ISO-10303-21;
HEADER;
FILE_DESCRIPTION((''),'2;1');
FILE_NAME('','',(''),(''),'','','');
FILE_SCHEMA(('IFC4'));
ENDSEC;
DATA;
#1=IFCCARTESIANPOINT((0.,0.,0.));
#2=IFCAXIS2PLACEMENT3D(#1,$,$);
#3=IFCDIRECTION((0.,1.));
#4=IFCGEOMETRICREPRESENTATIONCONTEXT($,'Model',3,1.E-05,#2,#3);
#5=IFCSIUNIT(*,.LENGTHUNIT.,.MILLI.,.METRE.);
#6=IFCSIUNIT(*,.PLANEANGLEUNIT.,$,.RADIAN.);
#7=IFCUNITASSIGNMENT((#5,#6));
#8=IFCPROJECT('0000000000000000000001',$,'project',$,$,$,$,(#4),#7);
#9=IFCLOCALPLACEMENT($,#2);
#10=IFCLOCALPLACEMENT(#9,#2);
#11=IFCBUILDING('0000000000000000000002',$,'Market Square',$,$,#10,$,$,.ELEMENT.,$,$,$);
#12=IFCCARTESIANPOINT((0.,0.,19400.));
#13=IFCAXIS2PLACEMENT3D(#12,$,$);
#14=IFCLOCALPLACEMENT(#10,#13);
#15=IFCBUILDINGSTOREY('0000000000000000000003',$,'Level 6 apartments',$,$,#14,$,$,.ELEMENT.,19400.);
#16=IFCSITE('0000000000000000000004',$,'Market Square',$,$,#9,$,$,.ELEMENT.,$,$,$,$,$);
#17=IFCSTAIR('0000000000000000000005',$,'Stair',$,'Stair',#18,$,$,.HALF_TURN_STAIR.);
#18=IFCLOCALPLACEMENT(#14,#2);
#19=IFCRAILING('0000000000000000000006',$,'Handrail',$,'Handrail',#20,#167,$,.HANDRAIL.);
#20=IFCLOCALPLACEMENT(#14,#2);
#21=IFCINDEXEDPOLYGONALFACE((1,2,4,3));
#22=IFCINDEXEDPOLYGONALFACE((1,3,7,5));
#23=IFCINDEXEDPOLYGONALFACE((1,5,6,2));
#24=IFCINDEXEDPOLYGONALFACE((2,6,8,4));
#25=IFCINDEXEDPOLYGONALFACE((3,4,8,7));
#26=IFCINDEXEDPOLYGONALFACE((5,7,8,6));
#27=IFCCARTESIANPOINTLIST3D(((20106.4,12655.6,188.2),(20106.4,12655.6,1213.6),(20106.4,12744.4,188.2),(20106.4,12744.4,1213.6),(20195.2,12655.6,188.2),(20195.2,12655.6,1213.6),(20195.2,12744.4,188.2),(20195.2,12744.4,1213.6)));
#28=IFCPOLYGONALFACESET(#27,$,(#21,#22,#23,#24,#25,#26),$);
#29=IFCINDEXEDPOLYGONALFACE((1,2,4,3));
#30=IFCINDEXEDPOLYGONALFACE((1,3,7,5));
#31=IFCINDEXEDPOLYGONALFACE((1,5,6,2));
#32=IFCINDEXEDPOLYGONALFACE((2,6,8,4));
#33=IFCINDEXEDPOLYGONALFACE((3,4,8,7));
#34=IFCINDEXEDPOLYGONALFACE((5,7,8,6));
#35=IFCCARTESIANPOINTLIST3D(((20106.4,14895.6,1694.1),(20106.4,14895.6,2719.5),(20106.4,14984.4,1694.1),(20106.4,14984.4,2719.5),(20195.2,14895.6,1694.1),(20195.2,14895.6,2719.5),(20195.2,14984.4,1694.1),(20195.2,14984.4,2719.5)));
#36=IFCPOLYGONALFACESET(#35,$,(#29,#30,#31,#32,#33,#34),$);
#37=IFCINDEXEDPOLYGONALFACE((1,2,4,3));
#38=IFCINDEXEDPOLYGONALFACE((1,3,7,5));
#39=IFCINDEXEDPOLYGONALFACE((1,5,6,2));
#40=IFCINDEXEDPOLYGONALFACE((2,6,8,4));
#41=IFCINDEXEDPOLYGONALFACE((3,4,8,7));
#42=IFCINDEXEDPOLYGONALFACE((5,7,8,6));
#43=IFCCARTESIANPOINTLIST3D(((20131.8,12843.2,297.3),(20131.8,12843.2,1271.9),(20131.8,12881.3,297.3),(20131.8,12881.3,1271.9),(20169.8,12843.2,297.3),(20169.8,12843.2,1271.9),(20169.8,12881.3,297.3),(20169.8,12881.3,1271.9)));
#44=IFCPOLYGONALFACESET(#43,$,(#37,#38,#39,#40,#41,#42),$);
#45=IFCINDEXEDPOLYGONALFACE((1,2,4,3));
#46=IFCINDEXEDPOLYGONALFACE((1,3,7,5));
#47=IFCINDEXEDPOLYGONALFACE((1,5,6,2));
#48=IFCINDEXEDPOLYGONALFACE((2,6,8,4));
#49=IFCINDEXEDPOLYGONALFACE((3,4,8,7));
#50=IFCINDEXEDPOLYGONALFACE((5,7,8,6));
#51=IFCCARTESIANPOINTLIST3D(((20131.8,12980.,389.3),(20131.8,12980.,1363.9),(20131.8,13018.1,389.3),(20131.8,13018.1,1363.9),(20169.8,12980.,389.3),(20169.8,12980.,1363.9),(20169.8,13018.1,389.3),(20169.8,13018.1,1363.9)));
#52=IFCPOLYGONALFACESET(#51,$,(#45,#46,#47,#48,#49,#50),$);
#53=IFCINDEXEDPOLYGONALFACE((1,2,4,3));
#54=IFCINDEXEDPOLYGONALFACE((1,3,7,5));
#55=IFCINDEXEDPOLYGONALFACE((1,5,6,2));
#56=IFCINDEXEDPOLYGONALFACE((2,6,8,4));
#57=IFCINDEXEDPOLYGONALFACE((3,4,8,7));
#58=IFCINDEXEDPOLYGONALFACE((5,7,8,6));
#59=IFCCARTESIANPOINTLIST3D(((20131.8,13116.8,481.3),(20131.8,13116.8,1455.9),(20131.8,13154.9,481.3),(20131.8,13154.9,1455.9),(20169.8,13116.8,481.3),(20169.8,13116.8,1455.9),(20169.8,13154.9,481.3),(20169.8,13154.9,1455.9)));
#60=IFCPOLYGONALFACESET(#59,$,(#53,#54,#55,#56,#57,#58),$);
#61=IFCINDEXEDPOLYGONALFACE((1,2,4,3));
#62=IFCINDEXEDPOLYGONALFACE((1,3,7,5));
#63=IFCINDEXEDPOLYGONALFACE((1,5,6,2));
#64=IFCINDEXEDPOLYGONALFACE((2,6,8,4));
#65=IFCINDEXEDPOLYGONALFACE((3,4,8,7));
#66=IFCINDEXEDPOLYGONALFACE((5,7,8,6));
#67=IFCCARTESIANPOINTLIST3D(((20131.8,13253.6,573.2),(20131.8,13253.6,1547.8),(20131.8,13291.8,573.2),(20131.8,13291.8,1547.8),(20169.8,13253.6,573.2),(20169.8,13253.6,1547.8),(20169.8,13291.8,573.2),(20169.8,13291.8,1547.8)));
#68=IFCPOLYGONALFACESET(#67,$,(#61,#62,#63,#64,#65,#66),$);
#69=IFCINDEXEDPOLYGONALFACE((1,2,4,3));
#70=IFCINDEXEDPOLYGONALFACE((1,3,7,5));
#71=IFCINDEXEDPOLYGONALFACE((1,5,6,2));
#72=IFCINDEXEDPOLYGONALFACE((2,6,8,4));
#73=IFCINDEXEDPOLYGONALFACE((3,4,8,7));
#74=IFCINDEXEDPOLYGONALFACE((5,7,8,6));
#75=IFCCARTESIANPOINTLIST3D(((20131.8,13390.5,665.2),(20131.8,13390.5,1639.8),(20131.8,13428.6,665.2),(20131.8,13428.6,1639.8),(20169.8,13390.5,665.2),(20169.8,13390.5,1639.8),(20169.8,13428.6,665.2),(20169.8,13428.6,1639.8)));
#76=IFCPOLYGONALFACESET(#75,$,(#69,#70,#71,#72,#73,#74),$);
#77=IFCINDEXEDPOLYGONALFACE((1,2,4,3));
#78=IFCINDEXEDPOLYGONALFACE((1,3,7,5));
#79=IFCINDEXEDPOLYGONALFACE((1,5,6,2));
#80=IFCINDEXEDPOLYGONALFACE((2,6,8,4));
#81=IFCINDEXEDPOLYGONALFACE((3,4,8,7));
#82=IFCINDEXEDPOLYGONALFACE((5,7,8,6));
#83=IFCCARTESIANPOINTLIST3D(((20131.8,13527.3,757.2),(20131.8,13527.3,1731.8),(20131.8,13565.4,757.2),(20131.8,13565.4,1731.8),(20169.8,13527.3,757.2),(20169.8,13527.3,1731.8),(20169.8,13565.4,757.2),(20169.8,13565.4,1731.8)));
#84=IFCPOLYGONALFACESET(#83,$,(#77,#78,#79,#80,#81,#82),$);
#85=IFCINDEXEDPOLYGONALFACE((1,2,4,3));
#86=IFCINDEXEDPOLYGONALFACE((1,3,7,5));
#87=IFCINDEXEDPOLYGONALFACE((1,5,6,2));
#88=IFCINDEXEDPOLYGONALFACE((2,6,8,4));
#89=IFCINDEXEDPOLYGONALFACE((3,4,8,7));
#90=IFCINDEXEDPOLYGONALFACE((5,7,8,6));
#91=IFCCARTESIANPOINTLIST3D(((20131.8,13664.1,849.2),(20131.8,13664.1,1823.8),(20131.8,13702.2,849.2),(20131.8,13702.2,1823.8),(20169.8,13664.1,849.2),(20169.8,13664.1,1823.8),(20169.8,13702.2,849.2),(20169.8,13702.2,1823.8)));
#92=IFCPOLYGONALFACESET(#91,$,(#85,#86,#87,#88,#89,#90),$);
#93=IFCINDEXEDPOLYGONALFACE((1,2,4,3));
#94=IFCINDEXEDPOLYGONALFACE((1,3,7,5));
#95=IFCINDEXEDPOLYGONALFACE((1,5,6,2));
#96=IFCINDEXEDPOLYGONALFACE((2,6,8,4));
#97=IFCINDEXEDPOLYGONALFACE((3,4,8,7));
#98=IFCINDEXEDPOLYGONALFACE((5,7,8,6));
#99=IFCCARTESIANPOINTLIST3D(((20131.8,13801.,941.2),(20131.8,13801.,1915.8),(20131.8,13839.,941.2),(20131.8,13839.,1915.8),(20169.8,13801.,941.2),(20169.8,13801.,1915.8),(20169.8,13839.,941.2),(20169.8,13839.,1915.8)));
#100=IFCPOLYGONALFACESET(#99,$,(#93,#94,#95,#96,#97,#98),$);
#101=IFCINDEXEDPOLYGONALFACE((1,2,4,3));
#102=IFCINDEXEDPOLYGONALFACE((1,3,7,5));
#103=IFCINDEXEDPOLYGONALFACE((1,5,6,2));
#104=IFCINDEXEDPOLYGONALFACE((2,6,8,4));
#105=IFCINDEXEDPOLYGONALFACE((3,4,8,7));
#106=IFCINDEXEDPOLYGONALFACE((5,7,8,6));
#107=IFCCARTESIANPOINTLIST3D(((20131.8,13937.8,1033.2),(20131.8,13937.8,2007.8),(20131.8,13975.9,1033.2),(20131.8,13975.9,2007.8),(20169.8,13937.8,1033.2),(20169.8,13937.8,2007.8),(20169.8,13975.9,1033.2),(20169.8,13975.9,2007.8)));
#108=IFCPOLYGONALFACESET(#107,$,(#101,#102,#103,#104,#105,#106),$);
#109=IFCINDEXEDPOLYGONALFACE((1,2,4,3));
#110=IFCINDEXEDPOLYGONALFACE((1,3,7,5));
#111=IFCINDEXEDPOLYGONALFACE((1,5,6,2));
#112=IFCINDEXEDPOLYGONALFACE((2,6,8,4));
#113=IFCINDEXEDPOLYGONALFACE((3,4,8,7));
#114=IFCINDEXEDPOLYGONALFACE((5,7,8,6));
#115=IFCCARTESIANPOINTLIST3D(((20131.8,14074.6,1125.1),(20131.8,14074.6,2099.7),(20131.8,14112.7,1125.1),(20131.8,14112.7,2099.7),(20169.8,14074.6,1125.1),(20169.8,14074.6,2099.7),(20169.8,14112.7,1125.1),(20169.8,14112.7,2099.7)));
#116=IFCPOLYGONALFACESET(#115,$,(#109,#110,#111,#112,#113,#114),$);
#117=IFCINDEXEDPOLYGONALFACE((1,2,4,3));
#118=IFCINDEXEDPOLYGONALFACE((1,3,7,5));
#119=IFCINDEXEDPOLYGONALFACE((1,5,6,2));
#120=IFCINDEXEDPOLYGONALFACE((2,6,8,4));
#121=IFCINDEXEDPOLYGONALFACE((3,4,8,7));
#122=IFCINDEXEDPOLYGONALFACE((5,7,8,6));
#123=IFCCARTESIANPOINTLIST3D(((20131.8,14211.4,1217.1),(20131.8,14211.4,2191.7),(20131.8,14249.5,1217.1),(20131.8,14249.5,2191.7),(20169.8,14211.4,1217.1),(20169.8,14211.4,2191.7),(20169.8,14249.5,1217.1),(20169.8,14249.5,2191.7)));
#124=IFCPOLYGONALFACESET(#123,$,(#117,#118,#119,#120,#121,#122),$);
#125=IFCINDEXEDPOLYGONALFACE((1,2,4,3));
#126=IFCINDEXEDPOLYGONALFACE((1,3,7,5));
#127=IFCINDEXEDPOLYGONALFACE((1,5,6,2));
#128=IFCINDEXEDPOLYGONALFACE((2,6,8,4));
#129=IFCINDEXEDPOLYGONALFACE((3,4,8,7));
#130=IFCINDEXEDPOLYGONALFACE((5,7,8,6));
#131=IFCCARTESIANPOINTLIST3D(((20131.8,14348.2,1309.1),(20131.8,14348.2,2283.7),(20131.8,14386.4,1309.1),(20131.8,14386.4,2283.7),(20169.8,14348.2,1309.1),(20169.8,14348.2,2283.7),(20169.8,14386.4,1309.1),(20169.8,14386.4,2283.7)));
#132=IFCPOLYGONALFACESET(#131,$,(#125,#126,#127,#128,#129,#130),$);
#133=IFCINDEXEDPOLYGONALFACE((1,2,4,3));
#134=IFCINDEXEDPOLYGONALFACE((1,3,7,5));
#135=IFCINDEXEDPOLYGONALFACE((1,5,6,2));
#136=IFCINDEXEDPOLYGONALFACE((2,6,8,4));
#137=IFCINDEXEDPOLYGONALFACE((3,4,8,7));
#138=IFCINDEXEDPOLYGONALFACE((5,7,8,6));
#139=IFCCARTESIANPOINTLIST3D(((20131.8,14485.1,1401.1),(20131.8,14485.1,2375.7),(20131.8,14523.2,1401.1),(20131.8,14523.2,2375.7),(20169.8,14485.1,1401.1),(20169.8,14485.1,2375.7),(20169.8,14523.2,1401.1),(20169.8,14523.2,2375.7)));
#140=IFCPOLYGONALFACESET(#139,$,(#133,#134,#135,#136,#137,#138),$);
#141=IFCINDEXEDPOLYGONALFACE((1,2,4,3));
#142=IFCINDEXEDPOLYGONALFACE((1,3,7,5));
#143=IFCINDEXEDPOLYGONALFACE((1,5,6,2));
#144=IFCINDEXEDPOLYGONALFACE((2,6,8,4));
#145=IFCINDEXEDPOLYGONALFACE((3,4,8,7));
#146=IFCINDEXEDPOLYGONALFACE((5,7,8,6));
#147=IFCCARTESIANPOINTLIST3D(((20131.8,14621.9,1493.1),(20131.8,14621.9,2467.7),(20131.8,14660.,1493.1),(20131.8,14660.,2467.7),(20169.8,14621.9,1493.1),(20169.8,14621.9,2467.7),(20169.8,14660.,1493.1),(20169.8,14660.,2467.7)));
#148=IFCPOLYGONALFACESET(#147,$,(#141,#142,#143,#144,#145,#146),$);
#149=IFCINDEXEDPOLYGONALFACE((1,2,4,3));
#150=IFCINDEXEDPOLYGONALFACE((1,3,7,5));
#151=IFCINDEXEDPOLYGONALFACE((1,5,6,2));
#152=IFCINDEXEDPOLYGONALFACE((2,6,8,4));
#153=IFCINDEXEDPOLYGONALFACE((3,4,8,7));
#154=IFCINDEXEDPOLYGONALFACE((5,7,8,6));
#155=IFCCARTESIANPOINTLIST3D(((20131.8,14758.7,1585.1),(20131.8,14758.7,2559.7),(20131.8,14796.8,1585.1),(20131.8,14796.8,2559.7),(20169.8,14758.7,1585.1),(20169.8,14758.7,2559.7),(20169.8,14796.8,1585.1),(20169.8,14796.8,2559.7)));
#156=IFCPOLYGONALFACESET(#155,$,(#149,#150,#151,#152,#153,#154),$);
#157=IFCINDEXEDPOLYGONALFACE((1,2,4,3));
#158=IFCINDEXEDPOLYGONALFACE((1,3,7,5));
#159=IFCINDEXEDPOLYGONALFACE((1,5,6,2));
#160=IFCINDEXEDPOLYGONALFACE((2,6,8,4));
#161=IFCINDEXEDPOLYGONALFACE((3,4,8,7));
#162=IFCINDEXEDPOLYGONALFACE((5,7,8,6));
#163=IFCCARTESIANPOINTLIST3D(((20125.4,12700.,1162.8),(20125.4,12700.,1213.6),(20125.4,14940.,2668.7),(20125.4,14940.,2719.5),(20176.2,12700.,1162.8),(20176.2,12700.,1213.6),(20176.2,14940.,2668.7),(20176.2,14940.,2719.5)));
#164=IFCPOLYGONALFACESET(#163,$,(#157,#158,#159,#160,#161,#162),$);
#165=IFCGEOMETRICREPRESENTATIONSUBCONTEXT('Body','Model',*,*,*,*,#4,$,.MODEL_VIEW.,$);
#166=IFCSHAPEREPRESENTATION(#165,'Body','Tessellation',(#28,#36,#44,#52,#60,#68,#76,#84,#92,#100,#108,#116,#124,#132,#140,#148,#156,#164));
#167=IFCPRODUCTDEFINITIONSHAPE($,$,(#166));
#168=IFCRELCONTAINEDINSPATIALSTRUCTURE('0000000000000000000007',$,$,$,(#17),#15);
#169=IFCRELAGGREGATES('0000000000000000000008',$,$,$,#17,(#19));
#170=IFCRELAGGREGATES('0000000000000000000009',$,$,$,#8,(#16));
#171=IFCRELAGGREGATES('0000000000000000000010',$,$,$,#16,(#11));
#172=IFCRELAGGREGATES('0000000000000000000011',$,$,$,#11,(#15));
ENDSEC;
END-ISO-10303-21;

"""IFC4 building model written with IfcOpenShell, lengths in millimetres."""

from ifc_helpers import new_model, si_unit, direction, frame, origin, origin_with_axes, place, context, subcontext, project, spatial, polyline, outline, extrude, element, aggregate, save


model = new_model("IFC4")

# Units and contexts
model_context = context("Model", 3, precision=1e-05, world=origin(), true_north=direction((0.0, 1.0)))
body_context = subcontext(model_context, "Body", "Model", "MODEL_VIEW")
ifc_project = project(units=[si_unit("LENGTHUNIT", "METRE", prefix="MILLI"), si_unit("PLANEANGLEUNIT", "RADIAN")], contexts=[model_context])

# Site, building, storey
site_placement = place(None, origin())
site = spatial("IfcSite", under=ifc_project, at=site_placement, Name="Market Square", CompositionType="ELEMENT")
building_placement = place(site_placement, origin())
building = spatial("IfcBuilding", under=site, at=building_placement, Name="Market Square", CompositionType="ELEMENT")
storey_placement = place(building_placement, frame((0.0, 0.0, 19400.0)))
storey = spatial("IfcBuildingStorey", under=building, at=storey_placement, Name="Level 6 apartments", CompositionType="ELEMENT", Elevation=19400.0)

# Stair
stair_placement = place(storey_placement, origin_with_axes())
stair = element("IfcStair", 1, at=stair_placement, inside=storey, Name="Stair", ObjectType="Stair", PredefinedType="HALF_TURN_STAIR")

# Railing
railing_1_placement = place(storey_placement, origin_with_axes())
railing_1 = element("IfcRailing", 2, at=railing_1_placement, Name="Handrail", ObjectType="Handrail", PredefinedType="HANDRAIL", context=body_context, shape_type="SweptSolid", body=[
    extrude(outline(polyline([(-44.5, -44.5), (44.5, -44.5), (44.5, 44.5), (-44.5, 44.5), (-44.5, -44.5)])), frame((20150.8, 12700.0, 188.2), z_axis=(0.0, 0.0, 1.0), x_axis=(1.0, 0.0, 0.0)), (0.0, 0.0, 1.0), 1025.4),
    extrude(outline(polyline([(-44.5, -44.5), (44.5, -44.5), (44.5, 44.5), (-44.5, 44.5), (-44.5, -44.5)])), frame((20150.8, 14940.0, 1694.1), z_axis=(0.0, 0.0, 1.0), x_axis=(1.0, 0.0, 0.0)), (0.0, 0.0, 1.0), 1025.4),
    extrude(outline(polyline([(-19.1, -19.1), (19.1, -19.1), (19.1, 19.1), (-19.1, 19.1), (-19.1, -19.1)])), frame((20150.8, 12862.2, 297.3), z_axis=(0.0, 0.0, 1.0), x_axis=(1.0, 0.0, 0.0)), (0.0, 0.0, 1.0), 974.6),
    extrude(outline(polyline([(-19.1, -19.1), (19.1, -19.1), (19.1, 19.1), (-19.1, 19.1), (-19.1, -19.1)])), frame((20150.8, 12999.0, 389.3), z_axis=(0.0, 0.0, 1.0), x_axis=(1.0, 0.0, 0.0)), (0.0, 0.0, 1.0), 974.6),
    extrude(outline(polyline([(-19.1, -19.1), (19.1, -19.1), (19.1, 19.1), (-19.1, 19.1), (-19.1, -19.1)])), frame((20150.8, 13135.9, 481.3), z_axis=(0.0, 0.0, 1.0), x_axis=(1.0, 0.0, 0.0)), (0.0, 0.0, 1.0), 974.6),
    extrude(outline(polyline([(-19.1, -19.1), (19.1, -19.1), (19.1, 19.1), (-19.1, 19.1), (-19.1, -19.1)])), frame((20150.8, 13272.7, 573.2), z_axis=(0.0, 0.0, 1.0), x_axis=(1.0, 0.0, 0.0)), (0.0, 0.0, 1.0), 974.6),
    extrude(outline(polyline([(-19.1, -19.1), (19.1, -19.1), (19.1, 19.1), (-19.1, 19.1), (-19.1, -19.1)])), frame((20150.8, 13409.5, 665.2), z_axis=(0.0, 0.0, 1.0), x_axis=(1.0, 0.0, 0.0)), (0.0, 0.0, 1.0), 974.6),
    extrude(outline(polyline([(-19.1, -19.1), (19.1, -19.1), (19.1, 19.1), (-19.1, 19.1), (-19.1, -19.1)])), frame((20150.8, 13546.4, 757.2), z_axis=(0.0, 0.0, 1.0), x_axis=(1.0, 0.0, 0.0)), (0.0, 0.0, 1.0), 974.6),
    extrude(outline(polyline([(-19.1, -19.1), (19.1, -19.1), (19.1, 19.1), (-19.1, 19.1), (-19.1, -19.1)])), frame((20150.8, 13683.2, 849.2), z_axis=(0.0, 0.0, 1.0), x_axis=(1.0, 0.0, 0.0)), (0.0, 0.0, 1.0), 974.6),
    extrude(outline(polyline([(-19.1, -19.1), (19.1, -19.1), (19.1, 19.1), (-19.1, 19.1), (-19.1, -19.1)])), frame((20150.8, 13820.0, 941.2), z_axis=(0.0, 0.0, 1.0), x_axis=(1.0, 0.0, 0.0)), (0.0, 0.0, 1.0), 974.6),
    extrude(outline(polyline([(-19.1, -19.1), (19.1, -19.1), (19.1, 19.1), (-19.1, 19.1), (-19.1, -19.1)])), frame((20150.8, 13956.8, 1033.2), z_axis=(0.0, 0.0, 1.0), x_axis=(1.0, 0.0, 0.0)), (0.0, 0.0, 1.0), 974.6),
    extrude(outline(polyline([(-19.1, -19.1), (19.1, -19.1), (19.1, 19.1), (-19.1, 19.1), (-19.1, -19.1)])), frame((20150.8, 14093.6, 1125.1), z_axis=(0.0, 0.0, 1.0), x_axis=(1.0, 0.0, 0.0)), (0.0, 0.0, 1.0), 974.6),
    extrude(outline(polyline([(-19.1, -19.1), (19.1, -19.1), (19.1, 19.1), (-19.1, 19.1), (-19.1, -19.1)])), frame((20150.8, 14230.5, 1217.1), z_axis=(0.0, 0.0, 1.0), x_axis=(1.0, 0.0, 0.0)), (0.0, 0.0, 1.0), 974.6),
    extrude(outline(polyline([(-19.1, -19.1), (19.1, -19.1), (19.1, 19.1), (-19.1, 19.1), (-19.1, -19.1)])), frame((20150.8, 14367.3, 1309.1), z_axis=(0.0, 0.0, 1.0), x_axis=(1.0, 0.0, 0.0)), (0.0, 0.0, 1.0), 974.6),
    extrude(outline(polyline([(-19.1, -19.1), (19.1, -19.1), (19.1, 19.1), (-19.1, 19.1), (-19.1, -19.1)])), frame((20150.8, 14504.1, 1401.1), z_axis=(0.0, 0.0, 1.0), x_axis=(1.0, 0.0, 0.0)), (0.0, 0.0, 1.0), 974.6),
    extrude(outline(polyline([(-19.1, -19.1), (19.1, -19.1), (19.1, 19.1), (-19.1, 19.1), (-19.1, -19.1)])), frame((20150.8, 14641.0, 1493.1), z_axis=(0.0, 0.0, 1.0), x_axis=(1.0, 0.0, 0.0)), (0.0, 0.0, 1.0), 974.6),
    extrude(outline(polyline([(-19.1, -19.1), (19.1, -19.1), (19.1, 19.1), (-19.1, 19.1), (-19.1, -19.1)])), frame((20150.8, 14777.8, 1585.1), z_axis=(0.0, 0.0, 1.0), x_axis=(1.0, 0.0, 0.0)), (0.0, 0.0, 1.0), 974.6),
    extrude(outline(polyline([(0.0, 0.0), (50.8, 0.0), (50.8, 50.8), (0.0, 50.8), (0.0, 0.0)])), frame((20176.2, 12700.0, 1162.8), z_axis=(0.0, 1.0, 0.0), x_axis=(-1.0, 0.0, 0.0)), (0.0, 0.557915, 0.829898), 2699.1),
])
aggregate(stair, [railing_1])

save(model, "model.ifc")
